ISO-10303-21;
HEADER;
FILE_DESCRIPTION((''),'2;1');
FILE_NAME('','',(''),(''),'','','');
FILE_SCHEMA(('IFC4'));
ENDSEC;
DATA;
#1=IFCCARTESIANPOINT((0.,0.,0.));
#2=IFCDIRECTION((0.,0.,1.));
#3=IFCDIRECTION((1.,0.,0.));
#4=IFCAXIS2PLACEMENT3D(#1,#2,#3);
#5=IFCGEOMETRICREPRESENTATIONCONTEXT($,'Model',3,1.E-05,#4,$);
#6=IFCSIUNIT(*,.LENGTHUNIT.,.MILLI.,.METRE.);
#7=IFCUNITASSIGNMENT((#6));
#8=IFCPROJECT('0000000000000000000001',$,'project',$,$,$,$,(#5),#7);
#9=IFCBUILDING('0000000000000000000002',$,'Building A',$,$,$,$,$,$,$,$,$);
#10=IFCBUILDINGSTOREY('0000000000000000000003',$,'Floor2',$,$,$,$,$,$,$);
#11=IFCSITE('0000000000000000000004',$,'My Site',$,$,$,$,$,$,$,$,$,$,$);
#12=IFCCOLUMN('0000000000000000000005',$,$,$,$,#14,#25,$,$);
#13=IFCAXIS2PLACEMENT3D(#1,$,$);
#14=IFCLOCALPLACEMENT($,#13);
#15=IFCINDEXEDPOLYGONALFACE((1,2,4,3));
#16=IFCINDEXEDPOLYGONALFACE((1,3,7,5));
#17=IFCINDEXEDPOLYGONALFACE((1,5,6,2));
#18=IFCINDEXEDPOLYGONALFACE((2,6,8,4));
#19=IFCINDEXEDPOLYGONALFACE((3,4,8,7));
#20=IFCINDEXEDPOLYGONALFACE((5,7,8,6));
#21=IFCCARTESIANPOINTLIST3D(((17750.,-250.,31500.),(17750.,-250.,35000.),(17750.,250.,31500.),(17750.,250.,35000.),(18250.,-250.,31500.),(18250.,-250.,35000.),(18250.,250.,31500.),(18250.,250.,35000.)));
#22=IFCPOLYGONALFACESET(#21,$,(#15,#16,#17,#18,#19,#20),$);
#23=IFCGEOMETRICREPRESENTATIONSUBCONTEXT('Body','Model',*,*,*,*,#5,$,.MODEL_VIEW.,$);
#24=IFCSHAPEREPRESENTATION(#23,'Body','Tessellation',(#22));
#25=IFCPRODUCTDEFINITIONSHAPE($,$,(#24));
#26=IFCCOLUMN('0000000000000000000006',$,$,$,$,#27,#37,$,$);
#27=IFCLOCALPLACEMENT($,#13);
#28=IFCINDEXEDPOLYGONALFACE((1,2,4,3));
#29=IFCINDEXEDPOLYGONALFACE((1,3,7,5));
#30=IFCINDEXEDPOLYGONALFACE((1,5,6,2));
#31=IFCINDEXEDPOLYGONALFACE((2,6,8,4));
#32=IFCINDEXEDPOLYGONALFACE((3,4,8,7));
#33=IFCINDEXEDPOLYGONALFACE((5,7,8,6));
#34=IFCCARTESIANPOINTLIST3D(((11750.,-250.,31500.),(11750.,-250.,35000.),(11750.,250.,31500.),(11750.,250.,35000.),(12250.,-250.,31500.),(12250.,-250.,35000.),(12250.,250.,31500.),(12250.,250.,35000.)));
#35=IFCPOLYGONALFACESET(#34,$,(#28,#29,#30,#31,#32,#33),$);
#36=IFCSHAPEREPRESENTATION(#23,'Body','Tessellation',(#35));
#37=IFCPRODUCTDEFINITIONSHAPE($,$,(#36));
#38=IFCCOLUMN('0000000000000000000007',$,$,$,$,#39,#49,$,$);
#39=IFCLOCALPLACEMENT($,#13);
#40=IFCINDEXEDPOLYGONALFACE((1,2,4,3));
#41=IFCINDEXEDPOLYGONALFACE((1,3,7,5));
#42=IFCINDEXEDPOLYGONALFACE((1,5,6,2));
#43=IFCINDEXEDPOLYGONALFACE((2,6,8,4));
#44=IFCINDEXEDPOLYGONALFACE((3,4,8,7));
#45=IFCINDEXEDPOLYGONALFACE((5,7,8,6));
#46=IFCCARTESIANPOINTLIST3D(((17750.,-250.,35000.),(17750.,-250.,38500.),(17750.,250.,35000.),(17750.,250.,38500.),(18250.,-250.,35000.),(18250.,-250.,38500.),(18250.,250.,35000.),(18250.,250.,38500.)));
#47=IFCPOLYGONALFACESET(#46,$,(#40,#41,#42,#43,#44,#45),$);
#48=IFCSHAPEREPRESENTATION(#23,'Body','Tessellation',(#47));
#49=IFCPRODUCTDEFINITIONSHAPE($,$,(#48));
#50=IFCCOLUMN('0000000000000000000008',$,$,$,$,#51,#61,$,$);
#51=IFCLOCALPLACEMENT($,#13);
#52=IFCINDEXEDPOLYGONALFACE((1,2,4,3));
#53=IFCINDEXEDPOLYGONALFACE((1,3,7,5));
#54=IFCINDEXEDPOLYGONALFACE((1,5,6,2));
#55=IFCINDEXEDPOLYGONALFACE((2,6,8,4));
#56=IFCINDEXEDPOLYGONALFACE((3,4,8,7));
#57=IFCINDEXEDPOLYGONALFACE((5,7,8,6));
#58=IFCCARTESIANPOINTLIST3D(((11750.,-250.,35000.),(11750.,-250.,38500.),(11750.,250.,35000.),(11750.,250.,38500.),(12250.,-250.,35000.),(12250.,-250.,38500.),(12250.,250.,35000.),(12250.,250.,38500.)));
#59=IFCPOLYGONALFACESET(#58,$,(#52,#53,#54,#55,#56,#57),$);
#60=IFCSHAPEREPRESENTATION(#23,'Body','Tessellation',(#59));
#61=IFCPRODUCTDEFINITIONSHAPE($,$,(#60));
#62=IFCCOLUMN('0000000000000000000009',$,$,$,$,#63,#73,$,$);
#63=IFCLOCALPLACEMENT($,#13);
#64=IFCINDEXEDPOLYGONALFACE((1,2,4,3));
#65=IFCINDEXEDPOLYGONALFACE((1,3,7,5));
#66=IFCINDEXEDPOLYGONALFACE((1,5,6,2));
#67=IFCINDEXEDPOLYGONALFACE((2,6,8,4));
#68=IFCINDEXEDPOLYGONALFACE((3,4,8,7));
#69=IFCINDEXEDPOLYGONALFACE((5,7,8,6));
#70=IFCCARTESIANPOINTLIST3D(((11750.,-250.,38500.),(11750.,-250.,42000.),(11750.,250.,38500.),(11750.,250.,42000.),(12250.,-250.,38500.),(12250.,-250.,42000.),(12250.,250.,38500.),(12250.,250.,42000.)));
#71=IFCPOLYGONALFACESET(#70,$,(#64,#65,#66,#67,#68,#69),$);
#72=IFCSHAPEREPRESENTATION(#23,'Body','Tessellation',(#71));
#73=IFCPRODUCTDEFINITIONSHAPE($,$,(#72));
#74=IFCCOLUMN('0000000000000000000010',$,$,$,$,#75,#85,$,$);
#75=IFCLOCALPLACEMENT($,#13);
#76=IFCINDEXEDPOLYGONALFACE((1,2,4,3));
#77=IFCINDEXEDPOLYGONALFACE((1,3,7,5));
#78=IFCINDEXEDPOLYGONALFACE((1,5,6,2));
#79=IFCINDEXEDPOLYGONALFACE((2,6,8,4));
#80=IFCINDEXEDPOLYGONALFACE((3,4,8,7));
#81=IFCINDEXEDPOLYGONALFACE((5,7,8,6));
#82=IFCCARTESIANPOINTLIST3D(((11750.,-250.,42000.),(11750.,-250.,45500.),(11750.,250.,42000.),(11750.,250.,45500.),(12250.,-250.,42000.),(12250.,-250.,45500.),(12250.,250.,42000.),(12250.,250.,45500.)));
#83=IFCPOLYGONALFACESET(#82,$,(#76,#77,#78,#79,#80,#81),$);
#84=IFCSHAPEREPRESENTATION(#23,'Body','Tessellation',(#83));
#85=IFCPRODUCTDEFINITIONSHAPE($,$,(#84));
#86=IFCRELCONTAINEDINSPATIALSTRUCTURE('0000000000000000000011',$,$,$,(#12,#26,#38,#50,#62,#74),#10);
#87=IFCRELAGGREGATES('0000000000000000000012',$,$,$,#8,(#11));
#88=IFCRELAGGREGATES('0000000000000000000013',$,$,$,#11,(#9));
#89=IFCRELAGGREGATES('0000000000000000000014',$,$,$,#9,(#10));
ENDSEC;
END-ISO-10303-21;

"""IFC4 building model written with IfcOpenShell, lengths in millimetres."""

from ifc_helpers import new_model, si_unit, frame, origin_with_axes, place, context, subcontext, project, spatial, line, indexed_curve, outline, extrude, element, save


model = new_model("IFC4")

# Units and contexts
model_context = context("Model", 3, precision=1e-05, world=origin_with_axes())
body_context = subcontext(model_context, "Body", "Model", "MODEL_VIEW")
ifc_project = project(units=[si_unit("LENGTHUNIT", "METRE", prefix="MILLI")], contexts=[model_context])

# Site, building, storey
site = spatial("IfcSite", under=ifc_project, Name="My Site")
building = spatial("IfcBuilding", under=site, Name="Building A")
storey = spatial("IfcBuildingStorey", under=building, Name="Floor2")

# Columns
for number, where, z_axis, x_axis in (
    (1, (18000.0, 0.0, 31500.0), (0.0, 0.0, 1.0), (1.0, 0.0, 0.0)),
    (2, (12000.0, 0.0, 31500.0), (0.0, 0.0, 1.0), (1.0, 0.0, 0.0)),
    (3, (18000.0, 0.0, 35000.0), (0.0, 0.0, 1.0), (1.0, 0.0, 0.0)),
    (4, (12000.0, 0.0, 35000.0), (0.0, 0.0, 1.0), (1.0, 0.0, 0.0)),
    (5, (12000.0, 0.0, 38500.0), (0.0, 0.0, 1.0), (1.0, 0.0, 0.0)),
    (6, (12000.0, 0.0, 42000.0), (0.0, 0.0, 1.0), (1.0, 0.0, 0.0)),
):
    element("IfcColumn", number, at=place(None, frame(where, z_axis=z_axis, x_axis=x_axis)), inside=storey, context=body_context, shape_type="SweptSolid", body=[
        extrude(outline(indexed_curve([(-250.0, -250.0), (250.0, -250.0), (250.0, 250.0), (-250.0, 250.0)], segments=[line(1, 2, 3, 4, 1)])), origin_with_axes(), (0.0, 0.0, 1.0), 3500.0),
    ])

save(model, "model.ifc")
